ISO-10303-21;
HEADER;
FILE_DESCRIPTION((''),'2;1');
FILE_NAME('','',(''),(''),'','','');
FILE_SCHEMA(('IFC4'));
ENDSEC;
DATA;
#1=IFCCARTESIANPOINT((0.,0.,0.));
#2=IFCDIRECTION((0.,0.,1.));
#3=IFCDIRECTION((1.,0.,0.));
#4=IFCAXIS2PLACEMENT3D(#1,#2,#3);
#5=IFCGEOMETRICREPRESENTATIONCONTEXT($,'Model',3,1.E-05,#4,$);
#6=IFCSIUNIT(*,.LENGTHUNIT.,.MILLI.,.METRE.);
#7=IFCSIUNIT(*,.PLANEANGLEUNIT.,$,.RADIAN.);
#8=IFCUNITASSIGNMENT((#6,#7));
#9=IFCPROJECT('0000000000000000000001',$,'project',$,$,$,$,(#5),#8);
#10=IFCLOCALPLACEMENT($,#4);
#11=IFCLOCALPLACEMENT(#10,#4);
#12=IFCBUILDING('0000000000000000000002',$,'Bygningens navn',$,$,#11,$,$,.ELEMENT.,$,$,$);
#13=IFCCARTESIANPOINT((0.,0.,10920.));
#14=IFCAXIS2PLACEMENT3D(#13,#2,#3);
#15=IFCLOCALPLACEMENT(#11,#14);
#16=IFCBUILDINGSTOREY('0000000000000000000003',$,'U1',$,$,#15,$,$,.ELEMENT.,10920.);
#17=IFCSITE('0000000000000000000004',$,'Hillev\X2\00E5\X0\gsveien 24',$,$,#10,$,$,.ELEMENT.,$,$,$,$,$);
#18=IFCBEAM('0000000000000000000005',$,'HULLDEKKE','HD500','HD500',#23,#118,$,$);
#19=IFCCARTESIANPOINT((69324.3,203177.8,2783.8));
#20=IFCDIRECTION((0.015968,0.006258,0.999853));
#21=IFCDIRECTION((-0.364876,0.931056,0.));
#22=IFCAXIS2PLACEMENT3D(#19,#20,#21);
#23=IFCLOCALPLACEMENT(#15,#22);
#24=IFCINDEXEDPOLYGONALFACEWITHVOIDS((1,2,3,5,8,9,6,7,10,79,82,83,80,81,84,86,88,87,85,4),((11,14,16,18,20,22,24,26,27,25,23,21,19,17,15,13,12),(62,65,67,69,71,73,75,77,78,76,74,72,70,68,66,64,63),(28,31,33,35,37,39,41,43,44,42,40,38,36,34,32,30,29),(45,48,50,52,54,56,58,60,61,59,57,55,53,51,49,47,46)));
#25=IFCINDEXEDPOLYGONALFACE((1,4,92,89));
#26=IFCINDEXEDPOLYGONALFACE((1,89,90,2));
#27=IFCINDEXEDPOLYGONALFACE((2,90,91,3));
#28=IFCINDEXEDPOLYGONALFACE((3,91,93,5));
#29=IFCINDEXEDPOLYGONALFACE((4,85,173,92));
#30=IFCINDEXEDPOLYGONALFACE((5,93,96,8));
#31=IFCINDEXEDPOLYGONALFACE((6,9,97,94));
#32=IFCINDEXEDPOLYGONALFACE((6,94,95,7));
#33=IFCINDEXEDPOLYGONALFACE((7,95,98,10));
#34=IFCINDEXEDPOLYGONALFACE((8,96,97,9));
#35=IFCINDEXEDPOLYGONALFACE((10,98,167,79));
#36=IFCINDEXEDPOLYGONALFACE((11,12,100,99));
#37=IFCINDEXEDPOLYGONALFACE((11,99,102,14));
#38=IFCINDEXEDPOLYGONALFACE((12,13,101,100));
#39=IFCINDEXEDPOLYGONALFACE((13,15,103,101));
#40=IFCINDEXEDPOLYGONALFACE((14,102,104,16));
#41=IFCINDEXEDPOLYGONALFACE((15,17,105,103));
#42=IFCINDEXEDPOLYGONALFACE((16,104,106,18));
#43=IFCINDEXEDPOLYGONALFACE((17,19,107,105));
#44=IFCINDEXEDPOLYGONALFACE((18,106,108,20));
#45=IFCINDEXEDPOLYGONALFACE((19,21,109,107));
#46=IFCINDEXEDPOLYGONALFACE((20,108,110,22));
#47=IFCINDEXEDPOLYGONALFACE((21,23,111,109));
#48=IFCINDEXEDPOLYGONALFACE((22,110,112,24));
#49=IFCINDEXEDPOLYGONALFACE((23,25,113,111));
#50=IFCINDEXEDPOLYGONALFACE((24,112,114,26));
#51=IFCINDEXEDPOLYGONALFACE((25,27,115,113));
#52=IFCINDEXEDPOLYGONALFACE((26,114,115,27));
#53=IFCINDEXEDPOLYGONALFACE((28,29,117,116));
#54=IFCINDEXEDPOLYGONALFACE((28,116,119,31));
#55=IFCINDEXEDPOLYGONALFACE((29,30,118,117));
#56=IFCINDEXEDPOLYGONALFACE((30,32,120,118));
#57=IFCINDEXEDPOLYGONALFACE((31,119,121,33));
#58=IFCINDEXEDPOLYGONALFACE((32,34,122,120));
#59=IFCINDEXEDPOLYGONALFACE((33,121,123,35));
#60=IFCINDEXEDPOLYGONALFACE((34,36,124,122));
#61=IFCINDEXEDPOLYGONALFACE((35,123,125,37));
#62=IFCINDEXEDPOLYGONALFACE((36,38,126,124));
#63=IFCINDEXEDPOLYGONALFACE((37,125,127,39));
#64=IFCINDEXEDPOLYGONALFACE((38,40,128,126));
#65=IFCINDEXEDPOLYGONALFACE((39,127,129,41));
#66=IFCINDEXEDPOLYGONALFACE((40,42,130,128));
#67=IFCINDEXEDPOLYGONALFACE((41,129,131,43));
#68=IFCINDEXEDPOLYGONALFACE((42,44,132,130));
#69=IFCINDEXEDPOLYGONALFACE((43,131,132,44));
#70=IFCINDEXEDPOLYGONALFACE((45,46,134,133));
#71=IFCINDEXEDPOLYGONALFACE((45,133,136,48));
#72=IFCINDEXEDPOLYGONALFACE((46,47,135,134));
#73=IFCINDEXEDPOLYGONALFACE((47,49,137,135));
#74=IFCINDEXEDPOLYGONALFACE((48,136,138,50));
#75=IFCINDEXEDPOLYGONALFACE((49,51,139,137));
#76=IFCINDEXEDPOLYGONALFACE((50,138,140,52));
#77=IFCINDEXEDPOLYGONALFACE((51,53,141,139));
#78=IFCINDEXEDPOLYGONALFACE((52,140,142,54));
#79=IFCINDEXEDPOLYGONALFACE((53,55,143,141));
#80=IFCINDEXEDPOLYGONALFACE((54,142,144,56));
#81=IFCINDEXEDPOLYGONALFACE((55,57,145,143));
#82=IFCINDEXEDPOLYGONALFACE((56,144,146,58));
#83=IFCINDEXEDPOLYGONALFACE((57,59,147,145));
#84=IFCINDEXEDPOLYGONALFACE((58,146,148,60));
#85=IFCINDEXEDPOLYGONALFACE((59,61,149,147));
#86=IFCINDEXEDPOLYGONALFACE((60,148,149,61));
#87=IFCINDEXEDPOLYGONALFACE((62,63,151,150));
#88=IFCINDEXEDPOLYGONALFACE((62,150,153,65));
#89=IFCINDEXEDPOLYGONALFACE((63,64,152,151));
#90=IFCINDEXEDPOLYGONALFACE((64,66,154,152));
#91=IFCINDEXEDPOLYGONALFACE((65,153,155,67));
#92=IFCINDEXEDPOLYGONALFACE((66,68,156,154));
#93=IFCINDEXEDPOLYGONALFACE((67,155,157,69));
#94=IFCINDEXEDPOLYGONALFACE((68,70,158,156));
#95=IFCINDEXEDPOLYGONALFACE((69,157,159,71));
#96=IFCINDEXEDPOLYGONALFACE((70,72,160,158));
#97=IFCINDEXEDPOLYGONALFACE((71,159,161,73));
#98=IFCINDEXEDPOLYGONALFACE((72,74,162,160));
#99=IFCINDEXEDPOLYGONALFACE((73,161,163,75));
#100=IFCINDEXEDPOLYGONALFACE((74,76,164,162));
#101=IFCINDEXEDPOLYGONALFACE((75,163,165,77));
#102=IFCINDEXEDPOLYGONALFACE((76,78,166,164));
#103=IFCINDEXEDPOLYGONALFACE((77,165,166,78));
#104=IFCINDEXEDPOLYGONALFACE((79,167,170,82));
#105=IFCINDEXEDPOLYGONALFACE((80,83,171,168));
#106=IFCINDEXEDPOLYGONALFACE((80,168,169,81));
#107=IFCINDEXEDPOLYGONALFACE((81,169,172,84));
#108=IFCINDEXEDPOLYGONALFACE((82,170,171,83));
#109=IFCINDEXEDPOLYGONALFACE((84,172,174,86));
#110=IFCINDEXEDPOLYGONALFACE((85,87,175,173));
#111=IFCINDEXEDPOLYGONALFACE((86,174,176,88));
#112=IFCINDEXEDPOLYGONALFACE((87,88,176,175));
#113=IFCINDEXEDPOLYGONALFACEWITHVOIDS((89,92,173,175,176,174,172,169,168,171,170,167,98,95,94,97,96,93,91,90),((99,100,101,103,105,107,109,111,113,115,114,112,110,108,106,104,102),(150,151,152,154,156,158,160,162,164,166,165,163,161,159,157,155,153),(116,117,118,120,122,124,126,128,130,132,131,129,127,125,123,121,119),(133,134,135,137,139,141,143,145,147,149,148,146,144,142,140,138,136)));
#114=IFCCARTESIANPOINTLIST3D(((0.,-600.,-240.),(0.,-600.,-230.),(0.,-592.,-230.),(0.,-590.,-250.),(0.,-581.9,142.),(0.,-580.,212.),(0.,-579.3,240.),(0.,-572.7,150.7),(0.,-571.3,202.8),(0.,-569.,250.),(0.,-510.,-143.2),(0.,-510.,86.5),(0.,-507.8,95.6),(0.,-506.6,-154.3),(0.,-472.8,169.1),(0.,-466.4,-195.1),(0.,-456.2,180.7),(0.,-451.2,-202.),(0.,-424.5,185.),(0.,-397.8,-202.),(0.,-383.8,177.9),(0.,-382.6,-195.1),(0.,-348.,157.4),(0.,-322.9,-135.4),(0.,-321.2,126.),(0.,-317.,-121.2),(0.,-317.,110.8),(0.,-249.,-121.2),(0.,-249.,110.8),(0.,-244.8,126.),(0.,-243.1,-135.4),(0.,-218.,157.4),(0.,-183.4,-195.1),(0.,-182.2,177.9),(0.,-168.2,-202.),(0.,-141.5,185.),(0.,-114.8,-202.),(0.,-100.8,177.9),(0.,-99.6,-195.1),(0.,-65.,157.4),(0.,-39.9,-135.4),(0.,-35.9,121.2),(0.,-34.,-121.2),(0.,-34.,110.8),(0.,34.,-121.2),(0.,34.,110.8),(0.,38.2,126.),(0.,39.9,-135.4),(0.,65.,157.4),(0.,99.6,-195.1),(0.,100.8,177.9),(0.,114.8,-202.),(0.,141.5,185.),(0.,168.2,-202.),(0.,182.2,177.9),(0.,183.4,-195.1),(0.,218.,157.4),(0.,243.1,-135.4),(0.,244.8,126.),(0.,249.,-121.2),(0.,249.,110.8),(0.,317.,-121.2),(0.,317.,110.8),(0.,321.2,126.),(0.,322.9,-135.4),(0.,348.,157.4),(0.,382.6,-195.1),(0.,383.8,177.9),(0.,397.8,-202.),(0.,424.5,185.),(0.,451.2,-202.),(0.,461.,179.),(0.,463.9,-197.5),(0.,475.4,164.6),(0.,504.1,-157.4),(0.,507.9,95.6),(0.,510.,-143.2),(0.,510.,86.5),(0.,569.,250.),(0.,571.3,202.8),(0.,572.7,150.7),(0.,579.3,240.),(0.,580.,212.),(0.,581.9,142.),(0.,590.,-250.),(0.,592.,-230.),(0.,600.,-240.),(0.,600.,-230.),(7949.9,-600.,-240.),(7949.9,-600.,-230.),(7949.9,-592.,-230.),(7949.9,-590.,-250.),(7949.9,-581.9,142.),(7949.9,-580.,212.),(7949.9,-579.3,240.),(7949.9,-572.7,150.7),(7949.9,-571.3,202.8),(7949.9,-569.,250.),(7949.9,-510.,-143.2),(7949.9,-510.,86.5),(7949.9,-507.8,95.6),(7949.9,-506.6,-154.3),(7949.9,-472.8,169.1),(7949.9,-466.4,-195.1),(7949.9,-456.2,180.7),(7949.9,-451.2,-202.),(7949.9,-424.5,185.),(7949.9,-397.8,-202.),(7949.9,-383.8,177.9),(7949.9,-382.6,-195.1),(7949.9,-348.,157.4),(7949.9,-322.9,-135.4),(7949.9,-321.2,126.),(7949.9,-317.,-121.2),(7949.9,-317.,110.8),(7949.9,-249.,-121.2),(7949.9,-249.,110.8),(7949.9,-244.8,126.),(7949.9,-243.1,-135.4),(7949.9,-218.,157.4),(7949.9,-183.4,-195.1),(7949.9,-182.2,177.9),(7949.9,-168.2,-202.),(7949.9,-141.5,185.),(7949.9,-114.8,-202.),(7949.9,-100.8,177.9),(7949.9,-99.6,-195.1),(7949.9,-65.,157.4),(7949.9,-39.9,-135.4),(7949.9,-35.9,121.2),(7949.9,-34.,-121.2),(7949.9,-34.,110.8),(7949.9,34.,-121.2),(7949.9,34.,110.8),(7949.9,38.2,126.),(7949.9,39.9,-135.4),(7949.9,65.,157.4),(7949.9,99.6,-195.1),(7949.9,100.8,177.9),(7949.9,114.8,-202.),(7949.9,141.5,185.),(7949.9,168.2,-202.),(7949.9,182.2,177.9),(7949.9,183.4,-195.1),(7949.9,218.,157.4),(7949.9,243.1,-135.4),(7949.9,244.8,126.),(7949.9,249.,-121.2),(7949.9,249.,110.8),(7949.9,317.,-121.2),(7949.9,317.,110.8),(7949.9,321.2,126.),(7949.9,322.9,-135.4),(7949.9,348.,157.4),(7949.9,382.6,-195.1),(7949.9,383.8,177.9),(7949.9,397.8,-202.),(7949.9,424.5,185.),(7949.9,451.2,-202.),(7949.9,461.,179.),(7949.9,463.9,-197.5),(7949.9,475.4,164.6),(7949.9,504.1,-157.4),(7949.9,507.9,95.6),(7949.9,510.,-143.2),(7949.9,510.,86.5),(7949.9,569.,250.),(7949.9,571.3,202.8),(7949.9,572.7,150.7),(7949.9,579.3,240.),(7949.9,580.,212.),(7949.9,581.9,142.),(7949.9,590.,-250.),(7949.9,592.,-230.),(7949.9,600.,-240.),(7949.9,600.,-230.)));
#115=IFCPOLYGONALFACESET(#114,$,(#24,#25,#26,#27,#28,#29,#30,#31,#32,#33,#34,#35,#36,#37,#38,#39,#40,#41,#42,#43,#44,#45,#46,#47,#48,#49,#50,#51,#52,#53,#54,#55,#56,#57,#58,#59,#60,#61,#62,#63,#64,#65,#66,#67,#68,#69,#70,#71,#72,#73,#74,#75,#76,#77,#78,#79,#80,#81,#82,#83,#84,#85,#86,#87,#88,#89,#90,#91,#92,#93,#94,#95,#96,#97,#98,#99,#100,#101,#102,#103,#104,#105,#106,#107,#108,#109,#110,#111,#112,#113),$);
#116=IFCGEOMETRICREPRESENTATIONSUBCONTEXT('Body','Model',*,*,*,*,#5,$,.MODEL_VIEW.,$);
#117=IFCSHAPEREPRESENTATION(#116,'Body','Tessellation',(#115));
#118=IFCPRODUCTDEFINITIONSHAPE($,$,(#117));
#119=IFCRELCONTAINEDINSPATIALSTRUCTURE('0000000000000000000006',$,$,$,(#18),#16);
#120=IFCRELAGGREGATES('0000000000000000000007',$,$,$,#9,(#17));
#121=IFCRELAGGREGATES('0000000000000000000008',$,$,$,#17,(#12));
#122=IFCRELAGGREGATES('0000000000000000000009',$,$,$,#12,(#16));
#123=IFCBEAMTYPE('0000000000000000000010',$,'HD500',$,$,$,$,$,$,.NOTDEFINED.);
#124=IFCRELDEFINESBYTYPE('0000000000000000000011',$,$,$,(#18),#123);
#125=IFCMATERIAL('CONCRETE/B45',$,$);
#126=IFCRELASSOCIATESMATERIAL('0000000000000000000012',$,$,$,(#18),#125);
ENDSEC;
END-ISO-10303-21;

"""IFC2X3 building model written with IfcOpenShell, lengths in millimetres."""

from ifc_helpers import new_model, si_unit, frame, origin_with_axes, place, context, subcontext, project, spatial, polyline, outline, extrude, material, type_object, element, save


model = new_model("IFC2X3")

# Units and contexts
model_context = context("Model", 3, precision=1e-05, world=origin_with_axes())
body_context = subcontext(model_context, "Body", "Model", "MODEL_VIEW")
ifc_project = project(units=[si_unit("LENGTHUNIT", "METRE", prefix="MILLI"), si_unit("PLANEANGLEUNIT", "RADIAN")], contexts=[model_context])

# Site, building, storey
site_placement = place(None, origin_with_axes())
site = spatial("IfcSite", under=ifc_project, at=site_placement, Name="Hillevågsveien 24", CompositionType="ELEMENT")
building_placement = place(site_placement, origin_with_axes())
building = spatial("IfcBuilding", under=site, at=building_placement, Name="Bygningens navn", CompositionType="ELEMENT")
storey_placement = place(building_placement, frame((0.0, 0.0, 10920.0), z_axis=(0.0, 0.0, 1.0), x_axis=(1.0, 0.0, 0.0)))
storey = spatial("IfcBuildingStorey", under=building, at=storey_placement, Name="U1", CompositionType="ELEMENT", Elevation=10920.0)

# Beam
ifc_material_1 = material(Name="CONCRETE/B45")
beam_type_1 = type_object("IfcBeamType", Name="HD500", PredefinedType="NOTDEFINED")
beam_1_placement = place(storey_placement, frame((69324.3, 203177.8, 2783.8), z_axis=(0.015968, 0.006258, 0.999853), x_axis=(-0.364876, 0.931056, 0.0)))
element("IfcBeam", 1, at=beam_1_placement, inside=storey, type_object=beam_type_1, material=ifc_material_1, Name="HULLDEKKE", Description="HD500", ObjectType="HD500", context=body_context, shape_type="SweptSolid", body=[
    extrude(outline(polyline([(581.9, 142.0), (592.0, -230.0), (600.0, -230.0), (600.0, -240.0), (590.0, -250.0), (-590.0, -250.0), (-600.0, -240.0), (-600.0, -230.0), (-592.0, -230.0), (-581.9, 142.0), (-572.7, 150.7), (-571.3, 202.8), (-580.0, 212.0), (-579.3, 240.0), (-569.0, 250.0), (569.0, 250.0), (579.3, 240.0), (580.0, 212.0), (571.3, 202.8), (572.7, 150.7), (581.9, 142.0)]), holes=[polyline([(466.4, -195.1), (506.6, -154.3), (510.0, -143.2), (510.0, 86.5), (507.8, 95.6), (472.8, 169.1), (456.2, 180.7), (424.5, 185.0), (383.8, 177.9), (348.0, 157.4), (321.2, 126.0), (317.0, 110.8), (317.0, -121.2), (322.9, -135.4), (382.6, -195.1), (397.8, -202.0), (451.2, -202.0), (466.4, -195.1)]), polyline([(183.4, -195.1), (243.1, -135.4), (249.0, -121.2), (249.0, 110.8), (244.8, 126.0), (218.0, 157.4), (182.2, 177.9), (141.5, 185.0), (100.8, 177.9), (65.0, 157.4), (35.9, 121.2), (34.0, 110.8), (34.0, -121.2), (39.9, -135.4), (99.6, -195.1), (114.8, -202.0), (168.2, -202.0), (183.4, -195.1)]), polyline([(-99.6, -195.1), (-39.9, -135.4), (-34.0, -121.2), (-34.0, 110.8), (-38.2, 126.0), (-65.0, 157.4), (-100.8, 177.9), (-141.5, 185.0), (-182.2, 177.9), (-218.0, 157.4), (-244.8, 126.0), (-249.0, 110.8), (-249.0, -121.2), (-243.1, -135.4), (-183.4, -195.1), (-168.2, -202.0), (-114.8, -202.0), (-99.6, -195.1)]), polyline([(-382.6, -195.1), (-322.9, -135.4), (-317.0, -121.2), (-317.0, 110.8), (-321.2, 126.0), (-348.0, 157.4), (-383.8, 177.9), (-424.5, 185.0), (-461.0, 179.0), (-475.4, 164.6), (-507.9, 95.6), (-510.0, 86.5), (-510.0, -143.2), (-504.1, -157.4), (-463.9, -197.5), (-451.2, -202.0), (-397.8, -202.0), (-382.6, -195.1)])]), frame((7949.9, 0.0, 0.0), z_axis=(-1.0, 0.0, 0.0), x_axis=(0.0, -1.0, 0.0)), (0.0, 0.0, 1.0), 7949.9),
])

save(model, "model.ifc")
